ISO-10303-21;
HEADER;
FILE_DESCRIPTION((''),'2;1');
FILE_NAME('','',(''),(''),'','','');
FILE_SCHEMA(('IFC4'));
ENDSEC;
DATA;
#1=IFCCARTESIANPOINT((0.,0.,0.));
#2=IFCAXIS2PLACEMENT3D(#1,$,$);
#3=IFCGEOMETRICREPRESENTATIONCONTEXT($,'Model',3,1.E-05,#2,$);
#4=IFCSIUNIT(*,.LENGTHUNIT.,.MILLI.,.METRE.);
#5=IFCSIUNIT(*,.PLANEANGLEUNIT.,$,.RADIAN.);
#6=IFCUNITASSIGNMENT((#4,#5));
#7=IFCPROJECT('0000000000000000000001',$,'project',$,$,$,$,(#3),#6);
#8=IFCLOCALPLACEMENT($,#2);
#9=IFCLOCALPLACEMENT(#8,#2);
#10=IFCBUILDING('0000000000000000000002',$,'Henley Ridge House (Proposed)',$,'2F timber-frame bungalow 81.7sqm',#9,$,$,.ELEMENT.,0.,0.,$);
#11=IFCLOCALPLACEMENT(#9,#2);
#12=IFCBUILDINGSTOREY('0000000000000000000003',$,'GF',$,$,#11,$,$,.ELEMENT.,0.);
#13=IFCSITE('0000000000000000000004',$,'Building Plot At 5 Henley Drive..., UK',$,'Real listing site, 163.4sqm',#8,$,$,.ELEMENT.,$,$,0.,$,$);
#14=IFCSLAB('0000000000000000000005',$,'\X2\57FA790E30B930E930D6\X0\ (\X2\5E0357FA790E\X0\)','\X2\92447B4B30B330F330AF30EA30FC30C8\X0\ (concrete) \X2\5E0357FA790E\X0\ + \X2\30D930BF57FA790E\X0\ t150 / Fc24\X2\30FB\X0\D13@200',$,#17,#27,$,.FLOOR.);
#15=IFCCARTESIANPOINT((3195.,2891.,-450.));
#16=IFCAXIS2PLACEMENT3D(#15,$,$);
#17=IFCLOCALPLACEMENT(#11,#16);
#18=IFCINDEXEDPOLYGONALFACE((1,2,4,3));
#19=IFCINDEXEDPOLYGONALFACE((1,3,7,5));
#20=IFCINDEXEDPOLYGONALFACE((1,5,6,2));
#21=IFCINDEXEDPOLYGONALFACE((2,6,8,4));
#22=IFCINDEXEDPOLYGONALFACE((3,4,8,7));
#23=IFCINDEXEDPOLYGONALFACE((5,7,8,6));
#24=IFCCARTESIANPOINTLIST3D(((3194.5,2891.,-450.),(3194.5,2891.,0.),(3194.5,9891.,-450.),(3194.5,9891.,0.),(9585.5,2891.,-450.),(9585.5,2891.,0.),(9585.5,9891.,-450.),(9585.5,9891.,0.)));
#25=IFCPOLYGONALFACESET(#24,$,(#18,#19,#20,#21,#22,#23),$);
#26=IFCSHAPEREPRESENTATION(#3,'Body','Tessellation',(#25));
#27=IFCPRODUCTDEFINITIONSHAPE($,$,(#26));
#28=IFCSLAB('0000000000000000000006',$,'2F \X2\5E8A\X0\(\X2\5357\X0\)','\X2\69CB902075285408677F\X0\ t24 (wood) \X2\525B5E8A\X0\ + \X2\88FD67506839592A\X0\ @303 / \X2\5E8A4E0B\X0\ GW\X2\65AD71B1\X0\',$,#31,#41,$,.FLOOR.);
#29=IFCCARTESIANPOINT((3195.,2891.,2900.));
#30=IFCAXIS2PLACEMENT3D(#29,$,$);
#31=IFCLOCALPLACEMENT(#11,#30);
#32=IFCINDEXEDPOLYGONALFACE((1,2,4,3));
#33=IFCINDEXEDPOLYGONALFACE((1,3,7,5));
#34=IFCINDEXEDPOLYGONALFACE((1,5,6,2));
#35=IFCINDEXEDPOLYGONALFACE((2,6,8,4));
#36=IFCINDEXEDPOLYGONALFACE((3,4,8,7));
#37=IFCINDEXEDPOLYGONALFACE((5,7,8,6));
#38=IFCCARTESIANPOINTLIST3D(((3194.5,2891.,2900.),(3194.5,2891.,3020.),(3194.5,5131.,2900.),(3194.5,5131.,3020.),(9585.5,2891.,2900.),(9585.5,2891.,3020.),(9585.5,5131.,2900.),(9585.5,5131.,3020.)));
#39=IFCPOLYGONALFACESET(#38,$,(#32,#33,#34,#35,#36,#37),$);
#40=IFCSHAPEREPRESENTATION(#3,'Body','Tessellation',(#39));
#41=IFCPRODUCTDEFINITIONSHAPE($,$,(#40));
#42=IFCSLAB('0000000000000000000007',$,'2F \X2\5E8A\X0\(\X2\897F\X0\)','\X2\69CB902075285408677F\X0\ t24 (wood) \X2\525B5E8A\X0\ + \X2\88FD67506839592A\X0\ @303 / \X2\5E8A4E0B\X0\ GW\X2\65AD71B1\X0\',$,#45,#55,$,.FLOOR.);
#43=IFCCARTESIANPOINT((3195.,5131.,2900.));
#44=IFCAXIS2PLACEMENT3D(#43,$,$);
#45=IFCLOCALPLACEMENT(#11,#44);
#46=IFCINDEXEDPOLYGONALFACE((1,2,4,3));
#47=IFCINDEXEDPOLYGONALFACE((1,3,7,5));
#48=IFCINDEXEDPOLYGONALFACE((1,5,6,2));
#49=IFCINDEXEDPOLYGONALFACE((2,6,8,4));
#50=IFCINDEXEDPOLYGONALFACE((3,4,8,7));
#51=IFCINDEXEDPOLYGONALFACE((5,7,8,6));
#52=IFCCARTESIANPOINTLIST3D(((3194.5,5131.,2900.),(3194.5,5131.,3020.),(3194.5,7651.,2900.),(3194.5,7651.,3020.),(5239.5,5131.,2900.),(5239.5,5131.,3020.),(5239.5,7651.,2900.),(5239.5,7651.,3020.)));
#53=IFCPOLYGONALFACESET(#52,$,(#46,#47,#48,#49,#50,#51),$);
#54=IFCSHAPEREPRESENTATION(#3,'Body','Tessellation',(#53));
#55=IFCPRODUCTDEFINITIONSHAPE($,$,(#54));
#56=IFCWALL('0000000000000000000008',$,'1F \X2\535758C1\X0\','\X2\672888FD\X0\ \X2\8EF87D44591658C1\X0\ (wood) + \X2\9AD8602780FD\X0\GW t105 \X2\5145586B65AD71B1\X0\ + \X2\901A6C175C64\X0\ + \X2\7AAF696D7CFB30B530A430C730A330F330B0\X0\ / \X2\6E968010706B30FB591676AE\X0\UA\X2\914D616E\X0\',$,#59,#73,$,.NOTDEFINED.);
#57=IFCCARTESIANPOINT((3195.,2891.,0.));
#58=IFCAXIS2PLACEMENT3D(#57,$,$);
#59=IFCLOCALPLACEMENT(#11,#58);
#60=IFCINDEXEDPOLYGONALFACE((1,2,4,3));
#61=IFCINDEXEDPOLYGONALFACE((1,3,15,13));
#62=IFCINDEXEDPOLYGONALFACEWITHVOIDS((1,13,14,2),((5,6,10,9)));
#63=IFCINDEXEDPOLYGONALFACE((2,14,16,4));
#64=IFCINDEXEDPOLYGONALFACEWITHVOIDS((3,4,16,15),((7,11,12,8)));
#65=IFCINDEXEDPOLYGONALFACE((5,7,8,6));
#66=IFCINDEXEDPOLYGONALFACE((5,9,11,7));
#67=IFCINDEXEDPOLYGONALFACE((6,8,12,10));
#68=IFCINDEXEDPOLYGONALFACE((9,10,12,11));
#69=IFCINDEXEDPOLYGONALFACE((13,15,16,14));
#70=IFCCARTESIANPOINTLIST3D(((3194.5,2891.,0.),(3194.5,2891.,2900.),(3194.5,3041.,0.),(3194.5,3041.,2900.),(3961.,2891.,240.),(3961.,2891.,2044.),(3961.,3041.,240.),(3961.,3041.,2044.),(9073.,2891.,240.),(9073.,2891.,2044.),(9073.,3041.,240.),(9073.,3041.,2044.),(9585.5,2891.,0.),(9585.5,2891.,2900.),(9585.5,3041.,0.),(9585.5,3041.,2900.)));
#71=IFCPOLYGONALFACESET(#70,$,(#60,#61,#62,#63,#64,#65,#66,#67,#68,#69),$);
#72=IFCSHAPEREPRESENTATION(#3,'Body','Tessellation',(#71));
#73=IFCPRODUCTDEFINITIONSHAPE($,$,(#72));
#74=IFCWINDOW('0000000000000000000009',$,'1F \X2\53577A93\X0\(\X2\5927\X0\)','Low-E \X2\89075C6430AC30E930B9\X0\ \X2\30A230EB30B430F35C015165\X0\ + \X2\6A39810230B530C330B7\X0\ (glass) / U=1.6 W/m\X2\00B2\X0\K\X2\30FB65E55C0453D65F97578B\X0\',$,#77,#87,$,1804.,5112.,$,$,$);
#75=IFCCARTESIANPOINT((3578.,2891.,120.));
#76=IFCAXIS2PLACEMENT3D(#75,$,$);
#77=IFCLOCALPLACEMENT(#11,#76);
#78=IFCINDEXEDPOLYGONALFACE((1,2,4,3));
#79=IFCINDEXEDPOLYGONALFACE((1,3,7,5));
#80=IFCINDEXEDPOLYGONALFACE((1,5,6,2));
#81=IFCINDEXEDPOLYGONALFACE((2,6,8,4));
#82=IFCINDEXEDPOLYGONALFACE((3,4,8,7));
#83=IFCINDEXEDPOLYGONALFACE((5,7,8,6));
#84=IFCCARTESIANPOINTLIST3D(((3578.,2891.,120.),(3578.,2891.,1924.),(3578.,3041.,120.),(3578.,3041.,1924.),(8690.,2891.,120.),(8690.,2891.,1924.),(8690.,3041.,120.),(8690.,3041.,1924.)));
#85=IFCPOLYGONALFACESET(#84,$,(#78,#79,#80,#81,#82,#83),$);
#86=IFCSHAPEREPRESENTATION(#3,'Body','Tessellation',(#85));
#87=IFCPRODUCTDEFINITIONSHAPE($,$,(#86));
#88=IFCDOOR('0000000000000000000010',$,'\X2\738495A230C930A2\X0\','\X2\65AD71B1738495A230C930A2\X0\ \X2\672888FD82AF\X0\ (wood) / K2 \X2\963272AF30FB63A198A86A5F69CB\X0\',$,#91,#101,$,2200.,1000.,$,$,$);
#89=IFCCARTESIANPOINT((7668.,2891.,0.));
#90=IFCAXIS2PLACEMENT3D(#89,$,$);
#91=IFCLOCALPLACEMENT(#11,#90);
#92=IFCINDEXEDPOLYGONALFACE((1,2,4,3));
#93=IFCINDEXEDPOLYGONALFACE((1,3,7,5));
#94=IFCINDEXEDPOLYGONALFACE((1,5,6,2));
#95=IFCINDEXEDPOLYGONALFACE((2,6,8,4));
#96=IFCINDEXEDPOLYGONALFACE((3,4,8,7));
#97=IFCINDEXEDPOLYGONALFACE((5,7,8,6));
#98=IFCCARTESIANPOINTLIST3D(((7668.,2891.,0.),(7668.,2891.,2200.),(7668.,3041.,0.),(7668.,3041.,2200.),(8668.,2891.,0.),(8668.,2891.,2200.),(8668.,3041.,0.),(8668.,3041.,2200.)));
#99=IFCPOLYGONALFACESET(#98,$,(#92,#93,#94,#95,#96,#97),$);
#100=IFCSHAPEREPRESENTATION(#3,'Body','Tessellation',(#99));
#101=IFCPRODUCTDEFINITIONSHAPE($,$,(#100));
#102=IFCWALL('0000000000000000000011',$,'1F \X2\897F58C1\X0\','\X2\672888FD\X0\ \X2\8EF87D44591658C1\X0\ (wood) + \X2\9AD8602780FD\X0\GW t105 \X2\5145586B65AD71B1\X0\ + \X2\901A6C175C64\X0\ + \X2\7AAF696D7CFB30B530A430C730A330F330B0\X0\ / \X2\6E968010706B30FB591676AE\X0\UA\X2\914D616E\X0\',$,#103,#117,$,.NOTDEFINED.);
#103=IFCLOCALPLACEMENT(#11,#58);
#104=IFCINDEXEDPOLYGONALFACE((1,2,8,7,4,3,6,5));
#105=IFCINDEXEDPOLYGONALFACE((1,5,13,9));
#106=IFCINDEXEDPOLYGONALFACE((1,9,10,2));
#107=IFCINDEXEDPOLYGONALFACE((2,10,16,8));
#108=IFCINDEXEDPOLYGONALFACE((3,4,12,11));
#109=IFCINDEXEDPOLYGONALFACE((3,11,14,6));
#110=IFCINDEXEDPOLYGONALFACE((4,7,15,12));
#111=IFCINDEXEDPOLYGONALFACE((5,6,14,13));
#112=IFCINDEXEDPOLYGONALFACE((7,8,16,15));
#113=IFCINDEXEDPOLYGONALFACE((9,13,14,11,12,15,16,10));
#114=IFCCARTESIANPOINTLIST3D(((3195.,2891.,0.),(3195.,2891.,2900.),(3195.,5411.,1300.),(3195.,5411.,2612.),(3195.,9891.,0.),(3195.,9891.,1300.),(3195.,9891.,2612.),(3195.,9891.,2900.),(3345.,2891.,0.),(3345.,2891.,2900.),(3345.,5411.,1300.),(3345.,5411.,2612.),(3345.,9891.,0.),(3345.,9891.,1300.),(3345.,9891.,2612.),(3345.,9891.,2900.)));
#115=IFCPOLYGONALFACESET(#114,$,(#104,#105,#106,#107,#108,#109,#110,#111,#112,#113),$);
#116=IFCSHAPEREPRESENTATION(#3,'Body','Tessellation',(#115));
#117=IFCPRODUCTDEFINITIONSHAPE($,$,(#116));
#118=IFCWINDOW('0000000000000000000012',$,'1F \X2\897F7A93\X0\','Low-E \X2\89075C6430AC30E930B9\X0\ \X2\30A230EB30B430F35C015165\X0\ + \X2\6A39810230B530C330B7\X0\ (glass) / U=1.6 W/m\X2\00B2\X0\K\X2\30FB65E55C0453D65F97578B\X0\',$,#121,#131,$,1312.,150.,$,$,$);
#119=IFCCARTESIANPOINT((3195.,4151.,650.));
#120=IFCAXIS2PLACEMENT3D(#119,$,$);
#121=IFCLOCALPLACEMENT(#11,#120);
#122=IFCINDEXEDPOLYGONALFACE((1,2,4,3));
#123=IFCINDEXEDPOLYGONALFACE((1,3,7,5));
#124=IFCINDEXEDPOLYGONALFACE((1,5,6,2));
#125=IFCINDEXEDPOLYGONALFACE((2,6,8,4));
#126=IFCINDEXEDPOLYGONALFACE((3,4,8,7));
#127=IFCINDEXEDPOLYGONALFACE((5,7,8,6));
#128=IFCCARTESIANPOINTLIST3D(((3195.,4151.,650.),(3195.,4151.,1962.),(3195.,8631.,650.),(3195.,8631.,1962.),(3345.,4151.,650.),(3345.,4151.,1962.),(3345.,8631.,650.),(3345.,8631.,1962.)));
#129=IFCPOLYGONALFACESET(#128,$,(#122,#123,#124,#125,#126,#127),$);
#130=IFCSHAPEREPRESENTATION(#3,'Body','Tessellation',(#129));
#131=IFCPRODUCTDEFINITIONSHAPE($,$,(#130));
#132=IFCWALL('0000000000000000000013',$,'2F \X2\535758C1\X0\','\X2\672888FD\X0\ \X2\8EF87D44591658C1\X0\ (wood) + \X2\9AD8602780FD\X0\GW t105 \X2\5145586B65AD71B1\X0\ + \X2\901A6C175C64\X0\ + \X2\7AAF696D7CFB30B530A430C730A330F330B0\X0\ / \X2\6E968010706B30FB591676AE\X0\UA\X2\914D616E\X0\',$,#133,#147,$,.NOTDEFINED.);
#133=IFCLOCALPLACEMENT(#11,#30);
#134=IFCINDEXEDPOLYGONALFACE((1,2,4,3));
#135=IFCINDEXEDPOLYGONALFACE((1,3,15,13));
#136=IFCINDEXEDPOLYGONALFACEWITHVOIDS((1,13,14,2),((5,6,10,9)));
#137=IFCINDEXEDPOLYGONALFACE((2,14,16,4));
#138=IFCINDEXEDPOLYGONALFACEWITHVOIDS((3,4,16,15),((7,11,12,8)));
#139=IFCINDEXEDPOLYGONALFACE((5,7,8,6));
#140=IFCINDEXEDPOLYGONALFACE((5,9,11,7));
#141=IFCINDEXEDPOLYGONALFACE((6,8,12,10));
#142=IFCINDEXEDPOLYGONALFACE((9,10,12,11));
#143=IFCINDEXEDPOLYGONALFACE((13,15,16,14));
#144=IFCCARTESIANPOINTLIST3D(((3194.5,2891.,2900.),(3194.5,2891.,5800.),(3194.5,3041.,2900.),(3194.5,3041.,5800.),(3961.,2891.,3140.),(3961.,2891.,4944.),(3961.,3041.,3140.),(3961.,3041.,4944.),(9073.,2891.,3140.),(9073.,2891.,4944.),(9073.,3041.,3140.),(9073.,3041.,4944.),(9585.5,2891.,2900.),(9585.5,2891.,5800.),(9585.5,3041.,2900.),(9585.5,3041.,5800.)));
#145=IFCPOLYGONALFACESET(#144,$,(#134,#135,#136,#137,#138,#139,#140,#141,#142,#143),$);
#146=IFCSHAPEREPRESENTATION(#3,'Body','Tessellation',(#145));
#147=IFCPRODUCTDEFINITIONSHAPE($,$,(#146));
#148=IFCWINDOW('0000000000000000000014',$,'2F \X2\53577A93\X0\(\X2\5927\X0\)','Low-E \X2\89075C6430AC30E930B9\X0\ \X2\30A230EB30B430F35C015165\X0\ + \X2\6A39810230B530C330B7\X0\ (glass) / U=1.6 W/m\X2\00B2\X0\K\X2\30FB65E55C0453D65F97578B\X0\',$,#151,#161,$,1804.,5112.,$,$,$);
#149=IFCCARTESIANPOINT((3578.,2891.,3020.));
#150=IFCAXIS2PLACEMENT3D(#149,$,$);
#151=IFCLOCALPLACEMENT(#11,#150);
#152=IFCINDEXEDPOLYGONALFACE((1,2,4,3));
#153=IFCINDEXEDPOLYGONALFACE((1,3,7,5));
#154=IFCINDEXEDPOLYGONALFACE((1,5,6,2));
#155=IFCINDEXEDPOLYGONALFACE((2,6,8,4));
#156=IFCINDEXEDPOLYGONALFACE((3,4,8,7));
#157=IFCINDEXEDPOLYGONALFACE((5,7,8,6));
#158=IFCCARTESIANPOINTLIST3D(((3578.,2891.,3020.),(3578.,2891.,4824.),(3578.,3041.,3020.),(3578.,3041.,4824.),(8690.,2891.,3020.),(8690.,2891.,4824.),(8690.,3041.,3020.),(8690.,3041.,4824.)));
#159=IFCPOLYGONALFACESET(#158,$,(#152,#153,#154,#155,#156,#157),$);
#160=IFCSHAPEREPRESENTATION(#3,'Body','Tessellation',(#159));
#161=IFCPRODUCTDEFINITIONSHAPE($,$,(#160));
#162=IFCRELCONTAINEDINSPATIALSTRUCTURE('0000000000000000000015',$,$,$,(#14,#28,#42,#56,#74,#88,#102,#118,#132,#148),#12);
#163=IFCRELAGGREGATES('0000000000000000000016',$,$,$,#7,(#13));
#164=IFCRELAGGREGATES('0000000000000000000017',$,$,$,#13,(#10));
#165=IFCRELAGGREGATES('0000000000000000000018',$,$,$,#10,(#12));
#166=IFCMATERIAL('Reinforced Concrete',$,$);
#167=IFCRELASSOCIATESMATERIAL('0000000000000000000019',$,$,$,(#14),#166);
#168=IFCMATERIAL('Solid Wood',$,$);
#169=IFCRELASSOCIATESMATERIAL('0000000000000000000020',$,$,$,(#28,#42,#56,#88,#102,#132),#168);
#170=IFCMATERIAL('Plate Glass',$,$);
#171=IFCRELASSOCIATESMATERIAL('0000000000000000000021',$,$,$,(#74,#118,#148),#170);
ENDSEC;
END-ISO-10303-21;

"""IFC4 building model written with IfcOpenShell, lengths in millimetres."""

from ifc_helpers import new_model, si_unit, frame, frame_2d, origin, place, context, project, spatial, rectangle, extrude, material, element, fill, save


model = new_model("IFC4")

# Units and contexts
model_context = context("Model", 3, precision=1e-05, world=origin())
ifc_project = project(units=[si_unit("LENGTHUNIT", "METRE", prefix="MILLI"), si_unit("PLANEANGLEUNIT", "RADIAN")], contexts=[model_context])

# Site, building, storey
site_placement = place(None, origin())
site = spatial("IfcSite", under=ifc_project, at=site_placement, Name="Building Plot At 5 Henley Drive..., UK", ObjectType="Real listing site, 163.4sqm", CompositionType="ELEMENT", RefElevation=0.0)
building_placement = place(site_placement, origin())
building = spatial("IfcBuilding", under=site, at=building_placement, Name="Henley Ridge House (Proposed)", ObjectType="2F timber-frame bungalow 81.7sqm", CompositionType="ELEMENT", ElevationOfRefHeight=0.0, ElevationOfTerrain=0.0)
storey_placement = place(building_placement, origin())
storey = spatial("IfcBuildingStorey", under=building, at=storey_placement, Name="GF", CompositionType="ELEMENT", Elevation=0.0)

# Slabs
ifc_material_1 = material(Name="Reinforced Concrete")
slab_1_placement = place(storey_placement, frame((3195.0, 2891.0, -450.0)))
element("IfcSlab", 1, at=slab_1_placement, inside=storey, material=ifc_material_1, Name="基礎スラブ (布基礎)", Description="鉄筋コンクリート (concrete) 布基礎 + ベタ基礎 t150 / Fc24・D13@200", PredefinedType="FLOOR", context=model_context, shape_type="SweptSolid", body=[
    extrude(rectangle(XDim=6391.0, YDim=7000.0, at=frame_2d((3195.0, 3500.0))), frame((3195.0, 2891.0, -450.0)), (0.0, 0.0, 1.0), 450.0),
])
ifc_material_2 = material(Name="Solid Wood")
slab_2_placement = place(storey_placement, frame((3195.0, 2891.0, 2900.0)))
element("IfcSlab", 2, at=slab_2_placement, inside=storey, material=ifc_material_2, Name="2F 床(南)", Description="構造用合板 t24 (wood) 剛床 + 製材根太 @303 / 床下 GW断熱", PredefinedType="FLOOR", context=model_context, shape_type="SweptSolid", body=[
    extrude(rectangle(XDim=6391.0, YDim=2240.0, at=frame_2d((3195.0, 1120.0))), frame((3195.0, 2891.0, 2900.0)), (0.0, 0.0, 1.0), 120.0),
])
slab_3_placement = place(storey_placement, frame((3195.0, 5131.0, 2900.0)))
element("IfcSlab", 3, at=slab_3_placement, inside=storey, material=ifc_material_2, Name="2F 床(西)", Description="構造用合板 t24 (wood) 剛床 + 製材根太 @303 / 床下 GW断熱", PredefinedType="FLOOR", context=model_context, shape_type="SweptSolid", body=[
    extrude(rectangle(XDim=2045.0, YDim=2520.0, at=frame_2d((1022.0, 1260.0))), frame((3195.0, 5131.0, 2900.0)), (0.0, 0.0, 1.0), 120.0),
])

# Wall, openings, window, door
wall_1_placement = place(storey_placement, frame((3195.0, 2891.0, 0.0)))
wall_1 = element("IfcWall", 4, at=wall_1_placement, inside=storey, material=ifc_material_2, Name="1F 南壁", Description="木製 軸組外壁 (wood) + 高性能GW t105 充填断熱 + 通気層 + 窯業系サイディング / 準耐火・外皮UA配慮", PredefinedType="NOTDEFINED", context=model_context, shape_type="SweptSolid", body=[
    extrude(rectangle(XDim=6391.0, YDim=150.0, at=frame_2d((3195.0, 75.0))), frame((3195.0, 2891.0, 0.0)), (0.0, 0.0, 1.0), 2900.0),
])
opening_1_placement = place(storey_placement, frame((3578.0, 2891.0, 120.0)))
opening_1 = element("IfcOpeningElement", 5, at=opening_1_placement, cuts=wall_1, PredefinedType="NOTDEFINED", context=model_context, shape_type="SweptSolid", body=[
    extrude(rectangle(XDim=5112.0, YDim=150.0, at=frame_2d((2556.0, 75.0))), frame((3578.0, 2891.0, 120.0)), (0.0, 0.0, 1.0), 1804.0),
])
opening_2_placement = place(storey_placement, frame((7668.0, 2891.0, 0.0)))
opening_2 = element("IfcOpeningElement", 6, at=opening_2_placement, cuts=wall_1, PredefinedType="NOTDEFINED", context=model_context, shape_type="SweptSolid", body=[
    extrude(rectangle(XDim=1000.0, YDim=150.0, at=frame_2d((500.0, 75.0))), frame((7668.0, 2891.0, 0.0)), (0.0, 0.0, 1.0), 2200.0),
])
ifc_material_3 = material(Name="Plate Glass")
window_1_placement = place(storey_placement, frame((3578.0, 2891.0, 120.0)))
window_1 = element("IfcWindow", 7, at=window_1_placement, inside=storey, material=ifc_material_3, Name="1F 南窓(大)", Description="Low-E 複層ガラス アルゴン封入 + 樹脂サッシ (glass) / U=1.6 W/m²K・日射取得型", OverallHeight=1804.0, OverallWidth=5112.0, context=model_context, shape_type="SweptSolid", body=[
    extrude(rectangle(XDim=5112.0, YDim=150.0, at=frame_2d((2556.0, 75.0))), frame((3578.0, 2891.0, 120.0)), (0.0, 0.0, 1.0), 1804.0),
])
fill(opening_1, window_1)
door_placement = place(storey_placement, frame((7668.0, 2891.0, 0.0)))
door = element("IfcDoor", 8, at=door_placement, inside=storey, material=ifc_material_2, Name="玄関ドア", Description="断熱玄関ドア 木製芯 (wood) / K2 防犯・採風機構", OverallHeight=2200.0, OverallWidth=1000.0, context=model_context, shape_type="SweptSolid", body=[
    extrude(rectangle(XDim=1000.0, YDim=150.0, at=frame_2d((500.0, 75.0))), frame((7668.0, 2891.0, 0.0)), (0.0, 0.0, 1.0), 2200.0),
])
fill(opening_2, door)

# Walls, openings, windows
wall_2_placement = place(storey_placement, frame((3195.0, 2891.0, 0.0)))
wall_2 = element("IfcWall", 9, at=wall_2_placement, inside=storey, material=ifc_material_2, Name="1F 西壁", Description="木製 軸組外壁 (wood) + 高性能GW t105 充填断熱 + 通気層 + 窯業系サイディング / 準耐火・外皮UA配慮", PredefinedType="NOTDEFINED", context=model_context, shape_type="SweptSolid", body=[
    extrude(rectangle(XDim=150.0, YDim=7000.0, at=frame_2d((75.0, 3500.0))), frame((3195.0, 2891.0, 0.0)), (0.0, 0.0, 1.0), 2900.0),
])
opening_3_placement = place(storey_placement, frame((3195.0, 4151.0, 650.0)))
opening_3 = element("IfcOpeningElement", 10, at=opening_3_placement, cuts=wall_2, PredefinedType="NOTDEFINED", context=model_context, shape_type="SweptSolid", body=[
    extrude(rectangle(XDim=150.0, YDim=4480.0, at=frame_2d((75.0, 2240.0))), frame((3195.0, 4151.0, 650.0)), (0.0, 0.0, 1.0), 1312.0),
])
window_2_placement = place(storey_placement, frame((3195.0, 4151.0, 650.0)))
window_2 = element("IfcWindow", 11, at=window_2_placement, inside=storey, material=ifc_material_3, Name="1F 西窓", Description="Low-E 複層ガラス アルゴン封入 + 樹脂サッシ (glass) / U=1.6 W/m²K・日射取得型", OverallHeight=1312.0, OverallWidth=150.0, context=model_context, shape_type="SweptSolid", body=[
    extrude(rectangle(XDim=150.0, YDim=4480.0, at=frame_2d((75.0, 2240.0))), frame((3195.0, 4151.0, 650.0)), (0.0, 0.0, 1.0), 1312.0),
])
fill(opening_3, window_2)
wall_3_placement = place(storey_placement, frame((3195.0, 2891.0, 2900.0)))
wall_3 = element("IfcWall", 12, at=wall_3_placement, inside=storey, material=ifc_material_2, Name="2F 南壁", Description="木製 軸組外壁 (wood) + 高性能GW t105 充填断熱 + 通気層 + 窯業系サイディング / 準耐火・外皮UA配慮", PredefinedType="NOTDEFINED", context=model_context, shape_type="SweptSolid", body=[
    extrude(rectangle(XDim=6391.0, YDim=150.0, at=frame_2d((3195.0, 75.0))), frame((3195.0, 2891.0, 2900.0)), (0.0, 0.0, 1.0), 2900.0),
])
opening_4_placement = place(storey_placement, frame((3578.0, 2891.0, 3020.0)))
opening_4 = element("IfcOpeningElement", 13, at=opening_4_placement, cuts=wall_3, PredefinedType="NOTDEFINED", context=model_context, shape_type="SweptSolid", body=[
    extrude(rectangle(XDim=5112.0, YDim=150.0, at=frame_2d((2556.0, 75.0))), frame((3578.0, 2891.0, 3020.0)), (0.0, 0.0, 1.0), 1804.0),
])
window_3_placement = place(storey_placement, frame((3578.0, 2891.0, 3020.0)))
window_3 = element("IfcWindow", 14, at=window_3_placement, inside=storey, material=ifc_material_3, Name="2F 南窓(大)", Description="Low-E 複層ガラス アルゴン封入 + 樹脂サッシ (glass) / U=1.6 W/m²K・日射取得型", OverallHeight=1804.0, OverallWidth=5112.0, context=model_context, shape_type="SweptSolid", body=[
    extrude(rectangle(XDim=5112.0, YDim=150.0, at=frame_2d((2556.0, 75.0))), frame((3578.0, 2891.0, 3020.0)), (0.0, 0.0, 1.0), 1804.0),
])
fill(opening_4, window_3)

save(model, "model.ifc")
